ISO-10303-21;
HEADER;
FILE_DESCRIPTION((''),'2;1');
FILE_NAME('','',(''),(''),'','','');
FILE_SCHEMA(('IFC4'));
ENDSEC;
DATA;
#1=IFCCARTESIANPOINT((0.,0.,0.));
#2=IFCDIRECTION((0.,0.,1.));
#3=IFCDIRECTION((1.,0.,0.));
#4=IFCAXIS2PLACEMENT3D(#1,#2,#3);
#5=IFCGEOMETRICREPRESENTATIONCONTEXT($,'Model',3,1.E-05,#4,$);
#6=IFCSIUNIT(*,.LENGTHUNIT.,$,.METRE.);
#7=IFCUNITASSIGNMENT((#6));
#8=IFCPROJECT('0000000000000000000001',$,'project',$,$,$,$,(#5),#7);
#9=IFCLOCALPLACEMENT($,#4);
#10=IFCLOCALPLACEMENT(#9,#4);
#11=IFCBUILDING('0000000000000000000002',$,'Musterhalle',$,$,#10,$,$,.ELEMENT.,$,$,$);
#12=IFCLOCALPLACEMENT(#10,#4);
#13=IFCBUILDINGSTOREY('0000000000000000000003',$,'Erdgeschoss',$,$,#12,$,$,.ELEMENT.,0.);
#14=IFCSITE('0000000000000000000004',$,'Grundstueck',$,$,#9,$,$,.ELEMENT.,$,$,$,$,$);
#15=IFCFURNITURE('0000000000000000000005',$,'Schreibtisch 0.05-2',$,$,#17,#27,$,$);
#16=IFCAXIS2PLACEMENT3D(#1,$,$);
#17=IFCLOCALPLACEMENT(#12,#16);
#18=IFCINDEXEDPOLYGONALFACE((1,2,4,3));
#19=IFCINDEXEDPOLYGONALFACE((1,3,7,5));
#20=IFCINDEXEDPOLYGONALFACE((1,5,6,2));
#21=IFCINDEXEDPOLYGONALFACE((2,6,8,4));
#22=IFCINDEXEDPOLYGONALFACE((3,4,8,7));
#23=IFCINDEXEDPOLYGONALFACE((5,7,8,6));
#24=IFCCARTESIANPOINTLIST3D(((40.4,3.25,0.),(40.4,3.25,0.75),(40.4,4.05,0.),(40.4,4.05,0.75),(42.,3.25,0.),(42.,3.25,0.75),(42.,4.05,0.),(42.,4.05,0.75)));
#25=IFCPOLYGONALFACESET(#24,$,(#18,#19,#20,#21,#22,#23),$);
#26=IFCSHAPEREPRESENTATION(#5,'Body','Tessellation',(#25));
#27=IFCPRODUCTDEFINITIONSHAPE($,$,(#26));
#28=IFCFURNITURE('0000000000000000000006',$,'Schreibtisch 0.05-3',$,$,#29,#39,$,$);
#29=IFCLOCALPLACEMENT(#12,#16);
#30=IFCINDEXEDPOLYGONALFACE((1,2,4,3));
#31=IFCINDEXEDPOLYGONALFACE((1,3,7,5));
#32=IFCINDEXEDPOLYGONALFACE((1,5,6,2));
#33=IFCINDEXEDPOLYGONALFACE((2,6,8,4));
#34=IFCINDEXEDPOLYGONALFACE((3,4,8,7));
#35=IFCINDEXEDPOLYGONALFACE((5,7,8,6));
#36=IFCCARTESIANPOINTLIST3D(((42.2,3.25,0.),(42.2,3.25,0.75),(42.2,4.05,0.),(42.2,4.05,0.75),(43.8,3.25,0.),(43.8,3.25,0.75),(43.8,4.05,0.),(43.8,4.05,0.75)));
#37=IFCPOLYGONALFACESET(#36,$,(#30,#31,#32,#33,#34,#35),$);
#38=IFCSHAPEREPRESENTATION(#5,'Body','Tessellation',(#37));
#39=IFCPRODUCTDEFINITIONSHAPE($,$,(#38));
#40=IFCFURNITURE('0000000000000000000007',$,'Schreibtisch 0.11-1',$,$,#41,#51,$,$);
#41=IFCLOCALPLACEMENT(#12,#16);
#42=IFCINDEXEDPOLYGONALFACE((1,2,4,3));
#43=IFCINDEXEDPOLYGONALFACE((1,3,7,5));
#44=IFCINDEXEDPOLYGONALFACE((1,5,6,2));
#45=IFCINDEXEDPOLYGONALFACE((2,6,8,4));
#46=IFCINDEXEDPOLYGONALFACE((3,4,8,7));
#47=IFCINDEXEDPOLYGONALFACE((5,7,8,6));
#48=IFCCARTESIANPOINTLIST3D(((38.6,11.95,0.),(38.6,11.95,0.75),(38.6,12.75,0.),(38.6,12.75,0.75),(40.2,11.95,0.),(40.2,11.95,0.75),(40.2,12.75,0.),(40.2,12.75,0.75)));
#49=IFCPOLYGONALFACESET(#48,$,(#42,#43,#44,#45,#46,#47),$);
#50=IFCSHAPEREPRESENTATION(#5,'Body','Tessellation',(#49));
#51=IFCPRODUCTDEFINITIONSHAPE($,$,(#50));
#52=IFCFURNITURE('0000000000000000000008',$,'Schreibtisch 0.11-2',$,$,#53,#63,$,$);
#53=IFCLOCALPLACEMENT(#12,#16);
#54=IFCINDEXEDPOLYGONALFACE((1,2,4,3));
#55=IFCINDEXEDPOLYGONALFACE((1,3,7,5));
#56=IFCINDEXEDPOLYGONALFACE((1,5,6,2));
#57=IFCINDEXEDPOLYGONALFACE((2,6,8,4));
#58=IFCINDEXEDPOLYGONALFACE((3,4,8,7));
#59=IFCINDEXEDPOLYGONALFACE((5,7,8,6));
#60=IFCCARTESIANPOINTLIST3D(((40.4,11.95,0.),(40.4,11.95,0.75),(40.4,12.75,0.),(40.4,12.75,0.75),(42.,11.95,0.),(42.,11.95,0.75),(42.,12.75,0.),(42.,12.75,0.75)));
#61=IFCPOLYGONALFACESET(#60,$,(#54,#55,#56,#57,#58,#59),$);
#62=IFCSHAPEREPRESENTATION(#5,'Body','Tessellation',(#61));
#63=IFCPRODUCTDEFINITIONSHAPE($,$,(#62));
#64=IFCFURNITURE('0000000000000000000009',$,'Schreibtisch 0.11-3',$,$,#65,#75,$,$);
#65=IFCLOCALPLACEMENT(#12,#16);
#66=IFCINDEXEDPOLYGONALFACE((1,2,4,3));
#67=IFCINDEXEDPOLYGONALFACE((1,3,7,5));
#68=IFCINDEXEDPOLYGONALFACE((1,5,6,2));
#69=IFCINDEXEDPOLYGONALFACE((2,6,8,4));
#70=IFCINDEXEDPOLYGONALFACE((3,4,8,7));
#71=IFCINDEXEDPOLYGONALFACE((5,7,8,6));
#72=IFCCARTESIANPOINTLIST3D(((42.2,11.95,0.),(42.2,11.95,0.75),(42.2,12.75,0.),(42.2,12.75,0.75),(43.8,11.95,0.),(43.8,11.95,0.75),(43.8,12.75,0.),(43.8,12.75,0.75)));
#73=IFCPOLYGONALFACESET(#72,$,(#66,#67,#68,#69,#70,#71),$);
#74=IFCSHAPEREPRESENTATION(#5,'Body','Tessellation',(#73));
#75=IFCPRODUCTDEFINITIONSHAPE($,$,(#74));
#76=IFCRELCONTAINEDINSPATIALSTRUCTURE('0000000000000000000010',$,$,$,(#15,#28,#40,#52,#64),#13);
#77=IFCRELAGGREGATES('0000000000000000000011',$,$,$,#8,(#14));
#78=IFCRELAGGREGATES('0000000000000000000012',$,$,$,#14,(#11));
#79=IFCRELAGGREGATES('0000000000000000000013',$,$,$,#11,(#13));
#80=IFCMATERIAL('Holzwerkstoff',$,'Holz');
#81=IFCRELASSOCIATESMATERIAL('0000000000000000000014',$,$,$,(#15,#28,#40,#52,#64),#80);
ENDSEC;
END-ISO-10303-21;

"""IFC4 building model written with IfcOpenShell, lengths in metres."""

from ifc_helpers import new_model, si_unit, frame, origin_with_axes, origin_2d, place, context, project, spatial, rectangle, extrude, material, element, save


model = new_model("IFC4")

# Units and contexts
model_context = context("Model", 3, precision=1e-05, world=origin_with_axes())
ifc_project = project(units=[si_unit("LENGTHUNIT", "METRE")], contexts=[model_context])

# Site, building, storey
site_placement = place(None, origin_with_axes())
site = spatial("IfcSite", under=ifc_project, at=site_placement, Name="Grundstueck", CompositionType="ELEMENT")
building_placement = place(site_placement, origin_with_axes())
building = spatial("IfcBuilding", under=site, at=building_placement, Name="Musterhalle", CompositionType="ELEMENT")
storey_placement = place(building_placement, origin_with_axes())
storey = spatial("IfcBuildingStorey", under=building, at=storey_placement, Name="Erdgeschoss", CompositionType="ELEMENT", Elevation=0.0)

# Shared definitions
placement = place(storey_placement, origin_with_axes())

# Shared definitions
ifc_material_1 = material(Name="Holzwerkstoff", Category="Holz")

# Furniture
element("IfcFurniture", 1, at=placement, inside=storey, material=ifc_material_1, Name="Schreibtisch 0.05-2", context=model_context, shape_type="SweptSolid", body=[
    extrude(rectangle(XDim=1.6, YDim=0.8, at=origin_2d()), frame((41.2, 3.65, 0.0), z_axis=(0.0, 0.0, 1.0), x_axis=(1.0, 0.0, 0.0)), (0.0, 0.0, 1.0), 0.75),
])
element("IfcFurniture", 2, at=placement, inside=storey, material=ifc_material_1, Name="Schreibtisch 0.05-3", context=model_context, shape_type="SweptSolid", body=[
    extrude(rectangle(XDim=1.6, YDim=0.8, at=origin_2d()), frame((43.0, 3.65, 0.0), z_axis=(0.0, 0.0, 1.0), x_axis=(1.0, 0.0, 0.0)), (0.0, 0.0, 1.0), 0.75),
])
element("IfcFurniture", 3, at=placement, inside=storey, material=ifc_material_1, Name="Schreibtisch 0.11-1", context=model_context, shape_type="SweptSolid", body=[
    extrude(rectangle(XDim=1.6, YDim=0.8, at=origin_2d()), frame((39.4, 12.35, 0.0), z_axis=(0.0, 0.0, 1.0), x_axis=(1.0, 0.0, 0.0)), (0.0, 0.0, 1.0), 0.75),
])
element("IfcFurniture", 4, at=placement, inside=storey, material=ifc_material_1, Name="Schreibtisch 0.11-2", context=model_context, shape_type="SweptSolid", body=[
    extrude(rectangle(XDim=1.6, YDim=0.8, at=origin_2d()), frame((41.2, 12.35, 0.0), z_axis=(0.0, 0.0, 1.0), x_axis=(1.0, 0.0, 0.0)), (0.0, 0.0, 1.0), 0.75),
])
element("IfcFurniture", 5, at=placement, inside=storey, material=ifc_material_1, Name="Schreibtisch 0.11-3", context=model_context, shape_type="SweptSolid", body=[
    extrude(rectangle(XDim=1.6, YDim=0.8, at=origin_2d()), frame((43.0, 12.35, 0.0), z_axis=(0.0, 0.0, 1.0), x_axis=(1.0, 0.0, 0.0)), (0.0, 0.0, 1.0), 0.75),
])

save(model, "model.ifc")
